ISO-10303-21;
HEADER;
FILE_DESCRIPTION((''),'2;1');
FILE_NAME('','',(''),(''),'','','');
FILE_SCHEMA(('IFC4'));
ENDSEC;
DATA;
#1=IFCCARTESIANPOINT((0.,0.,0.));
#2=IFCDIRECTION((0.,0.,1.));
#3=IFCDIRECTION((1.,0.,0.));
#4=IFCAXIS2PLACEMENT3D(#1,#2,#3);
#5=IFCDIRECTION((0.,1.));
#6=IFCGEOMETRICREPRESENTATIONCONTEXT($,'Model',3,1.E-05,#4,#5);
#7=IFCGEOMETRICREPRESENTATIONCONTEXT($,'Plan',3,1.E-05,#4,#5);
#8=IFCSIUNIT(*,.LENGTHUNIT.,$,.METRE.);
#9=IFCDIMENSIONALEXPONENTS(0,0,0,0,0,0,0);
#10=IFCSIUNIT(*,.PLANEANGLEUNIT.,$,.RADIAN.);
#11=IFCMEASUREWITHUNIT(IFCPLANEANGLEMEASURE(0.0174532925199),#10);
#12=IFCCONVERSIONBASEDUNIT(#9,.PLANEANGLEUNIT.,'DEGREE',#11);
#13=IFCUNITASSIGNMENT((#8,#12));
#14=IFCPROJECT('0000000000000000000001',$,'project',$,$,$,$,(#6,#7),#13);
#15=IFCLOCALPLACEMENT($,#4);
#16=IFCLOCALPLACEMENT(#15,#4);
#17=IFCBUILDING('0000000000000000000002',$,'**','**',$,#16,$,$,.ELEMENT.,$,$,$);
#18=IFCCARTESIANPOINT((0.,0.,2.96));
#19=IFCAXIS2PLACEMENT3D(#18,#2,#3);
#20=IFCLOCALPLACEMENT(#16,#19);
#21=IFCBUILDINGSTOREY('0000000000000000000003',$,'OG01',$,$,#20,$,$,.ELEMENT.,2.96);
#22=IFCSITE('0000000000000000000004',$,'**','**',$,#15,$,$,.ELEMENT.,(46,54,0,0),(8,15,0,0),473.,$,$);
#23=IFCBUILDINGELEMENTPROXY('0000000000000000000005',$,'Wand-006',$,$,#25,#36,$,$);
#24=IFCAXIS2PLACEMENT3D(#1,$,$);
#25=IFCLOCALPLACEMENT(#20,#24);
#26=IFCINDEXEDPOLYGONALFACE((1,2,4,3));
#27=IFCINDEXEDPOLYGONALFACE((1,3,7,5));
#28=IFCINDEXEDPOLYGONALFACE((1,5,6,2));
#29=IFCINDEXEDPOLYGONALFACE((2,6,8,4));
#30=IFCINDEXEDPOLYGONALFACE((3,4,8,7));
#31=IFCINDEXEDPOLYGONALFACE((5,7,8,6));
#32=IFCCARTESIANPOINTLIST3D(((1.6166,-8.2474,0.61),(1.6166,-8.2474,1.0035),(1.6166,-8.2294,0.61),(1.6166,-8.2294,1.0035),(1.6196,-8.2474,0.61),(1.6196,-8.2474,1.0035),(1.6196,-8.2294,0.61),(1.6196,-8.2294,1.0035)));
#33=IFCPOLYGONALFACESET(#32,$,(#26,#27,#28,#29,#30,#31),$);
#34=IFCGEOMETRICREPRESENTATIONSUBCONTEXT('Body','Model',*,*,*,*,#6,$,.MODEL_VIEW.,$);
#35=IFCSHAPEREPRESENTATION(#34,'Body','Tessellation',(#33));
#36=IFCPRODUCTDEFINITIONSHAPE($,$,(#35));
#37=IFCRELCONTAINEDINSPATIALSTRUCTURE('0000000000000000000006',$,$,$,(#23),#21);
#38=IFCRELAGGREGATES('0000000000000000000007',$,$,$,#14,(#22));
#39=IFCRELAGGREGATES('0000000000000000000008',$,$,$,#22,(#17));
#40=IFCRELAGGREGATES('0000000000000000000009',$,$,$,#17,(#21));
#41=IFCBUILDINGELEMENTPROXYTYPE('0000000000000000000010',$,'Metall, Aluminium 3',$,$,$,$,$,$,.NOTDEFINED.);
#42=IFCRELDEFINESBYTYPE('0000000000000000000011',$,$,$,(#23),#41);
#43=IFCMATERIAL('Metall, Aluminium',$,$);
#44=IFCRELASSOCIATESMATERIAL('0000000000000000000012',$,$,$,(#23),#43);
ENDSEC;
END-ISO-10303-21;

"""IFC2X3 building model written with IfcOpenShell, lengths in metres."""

from ifc_helpers import new_model, entity, si_unit, converted_unit, direction, frame, origin_with_axes, place, context, subcontext, project, spatial, polyline, outline, extrude, material, type_object, element, save


model = new_model("IFC2X3")

# Units and contexts
model_context = context("Model", 3, precision=1e-05, world=origin_with_axes(), true_north=direction((0.0, 1.0)))
plan_context = context("Plan", 3, precision=1e-05, world=origin_with_axes(), true_north=direction((0.0, 1.0)))
body_context = subcontext(model_context, "Body", "Model", "MODEL_VIEW")
ifc_project = project(units=[si_unit("LENGTHUNIT", "METRE"), converted_unit("PLANEANGLEUNIT", "DEGREE", entity("IfcPlaneAngleMeasure", 0.0174532925199), si_unit("PLANEANGLEUNIT", "RADIAN"), dimensions=[0, 0, 0, 0, 0, 0, 0])], contexts=[model_context, plan_context])

# Site, building, storey
site_placement = place(None, origin_with_axes())
site = spatial("IfcSite", under=ifc_project, at=site_placement, Name="**", Description="**", CompositionType="ELEMENT", RefLatitude=(46, 54, 0, 0), RefLongitude=(8, 15, 0, 0), RefElevation=473.0)
building_placement = place(site_placement, origin_with_axes())
building = spatial("IfcBuilding", under=site, at=building_placement, Name="**", Description="**", CompositionType="ELEMENT")
storey_placement = place(building_placement, frame((0.0, 0.0, 2.96), z_axis=(0.0, 0.0, 1.0), x_axis=(1.0, 0.0, 0.0)))
storey = spatial("IfcBuildingStorey", under=building, at=storey_placement, Name="OG01", CompositionType="ELEMENT", Elevation=2.96)

# Building element proxy
ifc_material_1 = material(Name="Metall, Aluminium")
building_element_proxy_type_1 = type_object("IfcBuildingElementProxyType", Name="Metall, Aluminium 3", PredefinedType="NOTDEFINED")
proxy_1_placement = place(storey_placement, frame((1.6166, -8.2294, 0.61), z_axis=(0.0, 0.0, 1.0), x_axis=(0.0, -1.0, 0.0)))
element("IfcBuildingElementProxy", 1, at=proxy_1_placement, inside=storey, type_object=building_element_proxy_type_1, material=ifc_material_1, Name="Wand-006", context=body_context, shape_type="SweptSolid", body=[
    extrude(outline(polyline([(0.0, 0.0), (0.018, 0.0), (0.018, 0.003), (0.0, 0.003), (0.0, 0.0)])), origin_with_axes(), (0.0, 0.0, 1.0), 0.3935),
])

save(model, "model.ifc")
